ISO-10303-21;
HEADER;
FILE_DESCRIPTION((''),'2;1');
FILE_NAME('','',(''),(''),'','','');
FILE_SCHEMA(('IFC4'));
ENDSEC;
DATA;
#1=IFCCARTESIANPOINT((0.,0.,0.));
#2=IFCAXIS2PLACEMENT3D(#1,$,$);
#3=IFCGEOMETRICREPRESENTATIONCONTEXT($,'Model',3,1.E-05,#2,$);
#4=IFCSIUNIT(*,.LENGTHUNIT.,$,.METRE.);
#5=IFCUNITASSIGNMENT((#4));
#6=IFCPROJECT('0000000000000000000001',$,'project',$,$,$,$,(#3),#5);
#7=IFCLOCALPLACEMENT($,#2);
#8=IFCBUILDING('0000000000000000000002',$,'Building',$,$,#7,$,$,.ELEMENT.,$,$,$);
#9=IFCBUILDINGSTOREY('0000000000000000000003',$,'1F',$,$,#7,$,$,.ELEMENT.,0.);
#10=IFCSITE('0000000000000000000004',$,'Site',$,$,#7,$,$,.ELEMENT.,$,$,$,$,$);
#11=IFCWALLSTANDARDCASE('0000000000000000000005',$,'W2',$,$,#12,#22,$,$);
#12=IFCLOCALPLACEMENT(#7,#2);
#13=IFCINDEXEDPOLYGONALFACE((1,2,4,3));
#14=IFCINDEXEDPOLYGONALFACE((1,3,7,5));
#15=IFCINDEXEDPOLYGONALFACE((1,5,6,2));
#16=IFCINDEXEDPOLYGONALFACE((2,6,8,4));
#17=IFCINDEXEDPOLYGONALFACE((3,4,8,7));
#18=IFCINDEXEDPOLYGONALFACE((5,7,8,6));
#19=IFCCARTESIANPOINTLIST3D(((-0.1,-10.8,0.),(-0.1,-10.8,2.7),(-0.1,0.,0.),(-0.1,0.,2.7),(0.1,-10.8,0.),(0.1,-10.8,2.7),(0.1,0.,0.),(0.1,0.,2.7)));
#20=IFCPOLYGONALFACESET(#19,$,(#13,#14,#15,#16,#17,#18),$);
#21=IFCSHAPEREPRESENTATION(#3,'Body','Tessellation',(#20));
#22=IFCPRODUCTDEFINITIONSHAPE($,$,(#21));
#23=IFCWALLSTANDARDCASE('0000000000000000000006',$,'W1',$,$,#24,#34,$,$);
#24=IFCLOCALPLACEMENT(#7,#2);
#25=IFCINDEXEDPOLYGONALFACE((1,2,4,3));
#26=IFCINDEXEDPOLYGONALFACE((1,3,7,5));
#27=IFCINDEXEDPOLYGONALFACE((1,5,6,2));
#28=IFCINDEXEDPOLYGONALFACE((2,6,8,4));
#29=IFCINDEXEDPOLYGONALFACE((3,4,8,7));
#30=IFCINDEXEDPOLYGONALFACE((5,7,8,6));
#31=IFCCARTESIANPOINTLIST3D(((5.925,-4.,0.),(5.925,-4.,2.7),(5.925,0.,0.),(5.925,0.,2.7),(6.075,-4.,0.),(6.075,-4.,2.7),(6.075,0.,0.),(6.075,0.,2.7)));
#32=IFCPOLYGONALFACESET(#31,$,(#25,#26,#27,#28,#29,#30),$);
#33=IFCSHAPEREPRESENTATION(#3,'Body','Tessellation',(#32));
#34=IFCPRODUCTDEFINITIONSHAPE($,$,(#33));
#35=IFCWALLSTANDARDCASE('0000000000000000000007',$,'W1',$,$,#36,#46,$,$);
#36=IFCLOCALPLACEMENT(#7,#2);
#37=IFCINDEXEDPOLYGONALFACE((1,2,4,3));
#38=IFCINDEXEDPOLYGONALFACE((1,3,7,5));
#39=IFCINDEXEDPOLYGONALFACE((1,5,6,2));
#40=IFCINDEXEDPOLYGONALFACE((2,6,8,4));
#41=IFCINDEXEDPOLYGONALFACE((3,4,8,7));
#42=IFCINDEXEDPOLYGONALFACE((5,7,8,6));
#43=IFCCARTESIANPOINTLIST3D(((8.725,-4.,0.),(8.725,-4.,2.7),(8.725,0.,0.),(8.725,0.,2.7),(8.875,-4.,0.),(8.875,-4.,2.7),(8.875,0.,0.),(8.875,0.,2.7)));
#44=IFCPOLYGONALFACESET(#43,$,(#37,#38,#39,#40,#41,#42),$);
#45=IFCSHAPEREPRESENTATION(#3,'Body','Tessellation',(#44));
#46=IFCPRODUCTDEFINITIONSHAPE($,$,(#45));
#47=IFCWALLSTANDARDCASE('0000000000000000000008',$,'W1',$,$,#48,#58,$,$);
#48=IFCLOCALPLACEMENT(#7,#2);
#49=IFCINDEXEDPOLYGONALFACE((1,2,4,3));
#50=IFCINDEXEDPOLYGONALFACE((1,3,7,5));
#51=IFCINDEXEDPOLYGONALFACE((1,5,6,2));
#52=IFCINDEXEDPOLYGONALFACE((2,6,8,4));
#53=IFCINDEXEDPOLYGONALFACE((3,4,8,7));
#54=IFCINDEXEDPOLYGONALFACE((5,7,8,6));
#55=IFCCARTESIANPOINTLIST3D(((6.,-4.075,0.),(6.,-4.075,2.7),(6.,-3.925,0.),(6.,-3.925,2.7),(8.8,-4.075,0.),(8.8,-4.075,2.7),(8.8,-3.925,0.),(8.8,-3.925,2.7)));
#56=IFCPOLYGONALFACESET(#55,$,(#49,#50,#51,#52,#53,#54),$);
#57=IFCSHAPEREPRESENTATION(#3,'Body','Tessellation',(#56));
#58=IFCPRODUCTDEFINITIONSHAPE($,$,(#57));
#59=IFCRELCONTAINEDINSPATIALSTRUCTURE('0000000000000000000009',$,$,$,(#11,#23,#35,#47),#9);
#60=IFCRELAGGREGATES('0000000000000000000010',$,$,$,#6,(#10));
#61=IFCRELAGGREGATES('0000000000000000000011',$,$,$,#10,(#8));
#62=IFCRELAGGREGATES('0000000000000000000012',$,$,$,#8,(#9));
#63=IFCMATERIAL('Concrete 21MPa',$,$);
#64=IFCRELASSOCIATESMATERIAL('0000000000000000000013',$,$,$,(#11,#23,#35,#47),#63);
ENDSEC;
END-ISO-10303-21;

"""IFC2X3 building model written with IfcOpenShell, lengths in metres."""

from ifc_helpers import new_model, si_unit, frame, origin, origin_2d, place, context, project, spatial, rectangle, extrude, material, element, save


model = new_model("IFC2X3")

# Units and contexts
model_context = context("Model", 3, precision=1e-05, world=origin())
ifc_project = project(units=[si_unit("LENGTHUNIT", "METRE")], contexts=[model_context])

# Site, building, storey
placement = place(None, origin())
site = spatial("IfcSite", under=ifc_project, at=placement, Name="Site", CompositionType="ELEMENT")
building = spatial("IfcBuilding", under=site, at=placement, Name="Building", CompositionType="ELEMENT")
storey = spatial("IfcBuildingStorey", under=building, at=placement, Name="1F", CompositionType="ELEMENT", Elevation=0.0)

# Shared definitions
ifc_material = material(Name="Concrete 21MPa")

# Walls
wall_1_placement = place(None, frame((0.0, -5.4, 0.0)))
element("IfcWallStandardCase", 1, at=wall_1_placement, inside=storey, material=ifc_material, Name="W2", context=model_context, shape_type="SweptSolid", body=[
    extrude(rectangle(XDim=0.2, YDim=10.8, at=origin_2d()), origin(), (0.0, 0.0, 1.0), 2.7),
])
for number, where, name in (
    (2, (6.0, -2.0, 0.0), "W1"),
    (3, (8.8, -2.0, 0.0), "W1"),
):
    element("IfcWallStandardCase", number, at=place(None, frame(where)), inside=storey, material=ifc_material, Name=name, context=model_context, shape_type="SweptSolid", body=[
        extrude(rectangle(XDim=0.15, YDim=4.0, at=origin_2d()), origin(), (0.0, 0.0, 1.0), 2.7),
    ])
wall_2_placement = place(None, frame((7.4, -4.0, 0.0)))
element("IfcWallStandardCase", 4, at=wall_2_placement, inside=storey, material=ifc_material, Name="W1", context=model_context, shape_type="SweptSolid", body=[
    extrude(rectangle(XDim=2.8, YDim=0.15, at=origin_2d()), origin(), (0.0, 0.0, 1.0), 2.7),
])

save(model, "model.ifc")
